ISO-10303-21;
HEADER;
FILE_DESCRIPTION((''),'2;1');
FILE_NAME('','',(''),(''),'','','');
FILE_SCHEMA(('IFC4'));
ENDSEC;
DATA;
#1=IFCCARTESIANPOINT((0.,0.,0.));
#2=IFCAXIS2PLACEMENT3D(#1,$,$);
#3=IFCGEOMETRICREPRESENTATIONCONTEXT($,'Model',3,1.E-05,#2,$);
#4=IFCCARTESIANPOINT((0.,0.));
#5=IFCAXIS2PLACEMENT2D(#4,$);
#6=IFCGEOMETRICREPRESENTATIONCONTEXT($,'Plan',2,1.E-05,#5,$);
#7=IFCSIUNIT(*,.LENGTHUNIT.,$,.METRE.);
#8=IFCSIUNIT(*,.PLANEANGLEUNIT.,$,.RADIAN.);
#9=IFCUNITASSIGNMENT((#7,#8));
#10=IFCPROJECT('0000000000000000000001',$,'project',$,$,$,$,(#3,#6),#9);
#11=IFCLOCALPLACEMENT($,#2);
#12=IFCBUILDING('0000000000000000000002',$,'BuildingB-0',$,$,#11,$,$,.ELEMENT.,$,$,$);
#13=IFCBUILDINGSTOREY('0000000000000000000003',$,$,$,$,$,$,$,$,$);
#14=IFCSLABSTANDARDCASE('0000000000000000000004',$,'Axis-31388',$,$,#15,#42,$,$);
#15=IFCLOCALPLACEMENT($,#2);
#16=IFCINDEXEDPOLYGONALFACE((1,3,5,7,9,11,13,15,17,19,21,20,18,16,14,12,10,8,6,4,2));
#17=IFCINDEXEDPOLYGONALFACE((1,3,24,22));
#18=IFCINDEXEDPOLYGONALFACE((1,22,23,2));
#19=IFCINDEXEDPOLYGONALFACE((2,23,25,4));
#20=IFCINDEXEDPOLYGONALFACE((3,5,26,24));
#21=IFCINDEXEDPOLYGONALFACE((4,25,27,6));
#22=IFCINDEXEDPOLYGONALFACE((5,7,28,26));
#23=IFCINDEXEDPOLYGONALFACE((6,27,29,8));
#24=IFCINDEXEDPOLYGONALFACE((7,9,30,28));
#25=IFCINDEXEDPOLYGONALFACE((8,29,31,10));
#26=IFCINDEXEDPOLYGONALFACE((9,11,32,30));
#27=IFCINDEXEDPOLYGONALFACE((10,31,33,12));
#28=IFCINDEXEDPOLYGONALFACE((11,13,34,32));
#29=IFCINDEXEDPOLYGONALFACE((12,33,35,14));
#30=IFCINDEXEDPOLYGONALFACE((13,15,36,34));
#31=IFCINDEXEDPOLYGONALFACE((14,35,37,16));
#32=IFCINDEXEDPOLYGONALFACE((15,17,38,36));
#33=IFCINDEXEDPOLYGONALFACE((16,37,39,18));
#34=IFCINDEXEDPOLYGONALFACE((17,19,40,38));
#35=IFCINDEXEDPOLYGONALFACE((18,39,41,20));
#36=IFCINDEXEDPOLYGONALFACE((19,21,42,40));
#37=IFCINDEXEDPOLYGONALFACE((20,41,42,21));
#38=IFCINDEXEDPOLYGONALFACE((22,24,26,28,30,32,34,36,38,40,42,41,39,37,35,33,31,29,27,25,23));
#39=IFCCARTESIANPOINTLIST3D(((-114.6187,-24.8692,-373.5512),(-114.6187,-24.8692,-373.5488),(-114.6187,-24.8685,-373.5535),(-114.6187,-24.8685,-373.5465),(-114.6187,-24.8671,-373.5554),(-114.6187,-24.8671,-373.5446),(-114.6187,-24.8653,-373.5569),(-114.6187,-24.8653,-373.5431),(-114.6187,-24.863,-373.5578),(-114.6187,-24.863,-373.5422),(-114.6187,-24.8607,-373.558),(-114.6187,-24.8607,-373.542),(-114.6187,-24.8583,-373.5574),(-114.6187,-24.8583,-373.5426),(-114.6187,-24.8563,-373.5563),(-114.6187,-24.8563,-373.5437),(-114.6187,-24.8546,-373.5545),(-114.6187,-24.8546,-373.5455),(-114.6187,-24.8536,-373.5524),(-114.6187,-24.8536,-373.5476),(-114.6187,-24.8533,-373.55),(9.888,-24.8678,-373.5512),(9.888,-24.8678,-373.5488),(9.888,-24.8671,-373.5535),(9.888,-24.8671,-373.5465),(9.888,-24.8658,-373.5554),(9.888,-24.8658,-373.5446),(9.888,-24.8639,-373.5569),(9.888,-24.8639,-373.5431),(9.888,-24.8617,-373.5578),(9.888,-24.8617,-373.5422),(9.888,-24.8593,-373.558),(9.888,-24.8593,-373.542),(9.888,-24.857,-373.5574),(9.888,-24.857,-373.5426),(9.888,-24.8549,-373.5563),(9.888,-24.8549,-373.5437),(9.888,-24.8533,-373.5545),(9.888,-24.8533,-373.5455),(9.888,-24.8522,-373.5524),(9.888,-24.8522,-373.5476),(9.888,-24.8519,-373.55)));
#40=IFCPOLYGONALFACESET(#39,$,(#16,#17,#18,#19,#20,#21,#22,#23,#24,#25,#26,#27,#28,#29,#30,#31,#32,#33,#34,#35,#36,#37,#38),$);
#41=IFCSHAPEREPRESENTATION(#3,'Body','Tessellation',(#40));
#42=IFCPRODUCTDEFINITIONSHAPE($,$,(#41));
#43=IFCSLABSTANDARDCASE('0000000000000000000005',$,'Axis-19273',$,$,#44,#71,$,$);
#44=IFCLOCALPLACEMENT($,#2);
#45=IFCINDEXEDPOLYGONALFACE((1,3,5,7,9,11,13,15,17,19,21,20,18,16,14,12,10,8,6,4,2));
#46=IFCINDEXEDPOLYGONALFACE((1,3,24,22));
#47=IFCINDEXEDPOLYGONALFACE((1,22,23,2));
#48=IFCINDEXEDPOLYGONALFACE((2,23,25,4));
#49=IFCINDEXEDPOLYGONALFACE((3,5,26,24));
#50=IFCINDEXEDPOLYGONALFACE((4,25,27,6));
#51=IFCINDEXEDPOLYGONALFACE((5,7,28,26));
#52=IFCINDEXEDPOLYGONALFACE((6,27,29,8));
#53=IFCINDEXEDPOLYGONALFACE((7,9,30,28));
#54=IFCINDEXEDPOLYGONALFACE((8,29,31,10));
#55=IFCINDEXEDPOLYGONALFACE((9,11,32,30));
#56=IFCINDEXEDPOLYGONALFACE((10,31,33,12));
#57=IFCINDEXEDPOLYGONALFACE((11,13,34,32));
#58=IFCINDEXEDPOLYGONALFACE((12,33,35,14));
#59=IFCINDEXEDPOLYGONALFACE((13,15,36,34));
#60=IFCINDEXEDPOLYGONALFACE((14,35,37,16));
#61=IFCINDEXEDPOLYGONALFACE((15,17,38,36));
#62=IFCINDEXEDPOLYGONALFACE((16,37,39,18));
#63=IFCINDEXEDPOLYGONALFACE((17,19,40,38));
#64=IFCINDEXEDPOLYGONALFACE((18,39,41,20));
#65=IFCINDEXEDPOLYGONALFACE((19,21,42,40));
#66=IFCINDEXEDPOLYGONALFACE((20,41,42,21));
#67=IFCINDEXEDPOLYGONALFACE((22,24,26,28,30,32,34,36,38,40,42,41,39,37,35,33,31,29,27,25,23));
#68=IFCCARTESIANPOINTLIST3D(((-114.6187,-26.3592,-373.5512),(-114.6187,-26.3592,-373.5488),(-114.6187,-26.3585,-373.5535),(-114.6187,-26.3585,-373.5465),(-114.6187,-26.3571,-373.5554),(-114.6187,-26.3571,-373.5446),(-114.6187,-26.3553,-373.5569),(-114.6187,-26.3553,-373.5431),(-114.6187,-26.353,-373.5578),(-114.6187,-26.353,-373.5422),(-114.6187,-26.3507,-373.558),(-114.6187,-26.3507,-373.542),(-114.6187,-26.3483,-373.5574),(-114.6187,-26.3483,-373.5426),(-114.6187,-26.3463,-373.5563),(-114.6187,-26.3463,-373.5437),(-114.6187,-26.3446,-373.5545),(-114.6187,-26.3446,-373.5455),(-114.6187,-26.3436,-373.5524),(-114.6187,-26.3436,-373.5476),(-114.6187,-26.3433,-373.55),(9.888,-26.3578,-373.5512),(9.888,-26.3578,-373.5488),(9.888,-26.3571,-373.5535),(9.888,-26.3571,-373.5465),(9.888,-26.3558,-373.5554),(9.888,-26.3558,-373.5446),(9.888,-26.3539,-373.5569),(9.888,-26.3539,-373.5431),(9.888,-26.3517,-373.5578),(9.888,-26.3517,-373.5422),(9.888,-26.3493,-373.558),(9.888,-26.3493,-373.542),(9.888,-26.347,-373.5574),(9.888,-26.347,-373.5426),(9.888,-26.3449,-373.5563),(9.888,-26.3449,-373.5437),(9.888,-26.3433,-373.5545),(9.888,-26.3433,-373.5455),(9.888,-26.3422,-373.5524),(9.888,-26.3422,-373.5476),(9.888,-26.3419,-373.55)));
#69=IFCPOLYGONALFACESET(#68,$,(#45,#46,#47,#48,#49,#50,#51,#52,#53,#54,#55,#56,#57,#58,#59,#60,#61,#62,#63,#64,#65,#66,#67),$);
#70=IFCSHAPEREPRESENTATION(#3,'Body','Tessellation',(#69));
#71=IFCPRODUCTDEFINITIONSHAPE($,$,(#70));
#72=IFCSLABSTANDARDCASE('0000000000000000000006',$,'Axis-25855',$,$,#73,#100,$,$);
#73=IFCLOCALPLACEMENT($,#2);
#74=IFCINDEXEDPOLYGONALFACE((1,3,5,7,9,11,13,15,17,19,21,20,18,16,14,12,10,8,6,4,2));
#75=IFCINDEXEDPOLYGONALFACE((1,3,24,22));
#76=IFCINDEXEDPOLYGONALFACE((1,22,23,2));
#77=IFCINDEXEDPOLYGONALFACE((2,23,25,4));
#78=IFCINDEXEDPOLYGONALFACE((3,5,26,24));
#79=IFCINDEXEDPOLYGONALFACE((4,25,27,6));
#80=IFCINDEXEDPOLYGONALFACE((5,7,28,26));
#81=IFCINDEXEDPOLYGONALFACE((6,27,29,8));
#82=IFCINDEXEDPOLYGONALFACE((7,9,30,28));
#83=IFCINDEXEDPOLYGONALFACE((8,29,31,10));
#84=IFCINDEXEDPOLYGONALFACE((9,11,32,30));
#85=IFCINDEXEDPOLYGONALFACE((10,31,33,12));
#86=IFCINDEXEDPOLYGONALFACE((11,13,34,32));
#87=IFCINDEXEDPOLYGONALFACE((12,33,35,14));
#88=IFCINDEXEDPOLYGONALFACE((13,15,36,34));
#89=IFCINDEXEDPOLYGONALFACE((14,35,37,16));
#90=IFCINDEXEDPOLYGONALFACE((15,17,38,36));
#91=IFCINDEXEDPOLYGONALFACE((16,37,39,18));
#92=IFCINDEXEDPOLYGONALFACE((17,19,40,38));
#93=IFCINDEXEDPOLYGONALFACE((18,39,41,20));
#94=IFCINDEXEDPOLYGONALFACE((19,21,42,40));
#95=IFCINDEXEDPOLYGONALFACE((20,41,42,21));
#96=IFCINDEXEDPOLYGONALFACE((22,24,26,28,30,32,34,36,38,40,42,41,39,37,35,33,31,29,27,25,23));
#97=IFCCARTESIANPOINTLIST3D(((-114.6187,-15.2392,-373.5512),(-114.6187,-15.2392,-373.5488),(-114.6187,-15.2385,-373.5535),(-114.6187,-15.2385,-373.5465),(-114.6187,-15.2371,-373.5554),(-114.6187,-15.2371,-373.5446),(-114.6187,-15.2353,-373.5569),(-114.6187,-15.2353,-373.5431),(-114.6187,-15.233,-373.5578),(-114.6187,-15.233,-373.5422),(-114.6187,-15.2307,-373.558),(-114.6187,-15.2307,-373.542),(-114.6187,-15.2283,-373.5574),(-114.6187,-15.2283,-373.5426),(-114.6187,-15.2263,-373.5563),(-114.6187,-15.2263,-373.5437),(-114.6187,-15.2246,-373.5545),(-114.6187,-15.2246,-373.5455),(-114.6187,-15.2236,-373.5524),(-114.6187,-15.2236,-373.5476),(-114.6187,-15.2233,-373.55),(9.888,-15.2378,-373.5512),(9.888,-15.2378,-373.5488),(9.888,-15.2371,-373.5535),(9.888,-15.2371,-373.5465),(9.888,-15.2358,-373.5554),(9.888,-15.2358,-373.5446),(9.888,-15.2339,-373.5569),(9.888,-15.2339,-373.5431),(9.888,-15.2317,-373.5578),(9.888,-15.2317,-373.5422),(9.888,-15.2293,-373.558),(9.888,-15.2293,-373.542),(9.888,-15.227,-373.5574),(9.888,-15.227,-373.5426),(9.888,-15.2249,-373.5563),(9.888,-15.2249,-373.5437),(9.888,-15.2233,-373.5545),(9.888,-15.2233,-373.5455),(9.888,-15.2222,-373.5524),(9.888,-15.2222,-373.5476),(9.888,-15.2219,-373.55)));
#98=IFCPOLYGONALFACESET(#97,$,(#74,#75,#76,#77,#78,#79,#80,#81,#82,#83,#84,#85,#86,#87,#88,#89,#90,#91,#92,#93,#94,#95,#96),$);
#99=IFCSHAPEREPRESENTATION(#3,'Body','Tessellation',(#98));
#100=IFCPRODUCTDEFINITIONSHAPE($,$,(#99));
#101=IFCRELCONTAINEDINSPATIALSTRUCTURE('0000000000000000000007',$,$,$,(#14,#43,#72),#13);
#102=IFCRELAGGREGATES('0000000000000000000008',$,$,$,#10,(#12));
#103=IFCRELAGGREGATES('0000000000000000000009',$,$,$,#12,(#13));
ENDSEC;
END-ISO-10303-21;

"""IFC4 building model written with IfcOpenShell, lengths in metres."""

from ifc_helpers import new_model, entity, si_unit, origin, origin_2d, place, context, project, spatial, element, save


model = new_model("IFC4")

# Units and contexts
model_context = context("Model", 3, precision=1e-05, world=origin())
plan_context = context("Plan", 2, precision=1e-05, world=origin_2d())
ifc_project = project(units=[si_unit("LENGTHUNIT", "METRE"), si_unit("PLANEANGLEUNIT", "RADIAN")], contexts=[model_context, plan_context])

# Building, storey
building_placement = place(None, origin())
building = spatial("IfcBuilding", under=ifc_project, at=building_placement, Name="BuildingB-0", CompositionType="ELEMENT")
storey = spatial("IfcBuildingStorey", under=building)

# Slabs
element("IfcSlabStandardCase", 1, inside=storey, Name="Axis-31388", context=model_context, shape_type="AdvancedSweptSolid", body=[
    entity("IfcSurfaceCurveSweptAreaSolid", entity("IfcCircleProfileDef", "AREA", None, None, 0.008), None, entity("IfcPolyline", [entity("IfcCartesianPoint", [-9.888, 24.8599, 373.55]), entity("IfcCartesianPoint", [114.6187, 24.8613, 373.55])]), None, None, entity("IfcPlane", entity("IfcAxis2Placement3D", entity("IfcCartesianPoint", [-9.888, 24.8599, 373.55]), entity("IfcDirection", [0.0, 0.0, 1.0]), entity("IfcDirection", [1.0, 0.0, 0.0])))),
    entity("IfcSurfaceCurveSweptAreaSolid", entity("IfcCircleProfileDef", "AREA", None, None, 0.008), None, entity("IfcCircle", entity("IfcAxis2Placement2D", entity("IfcCartesianPoint", [-10.1215, 24.8599, 373.55])), 0.35), None, None, entity("IfcPlane", entity("IfcAxis2Placement3D", entity("IfcCartesianPoint", [-10.1215, 24.8599, 373.55]), entity("IfcDirection", [0.0, 0.0, 1.0]), entity("IfcDirection", [1.0, 0.0, 0.0])))),
    entity("IfcSurfaceCurveSweptAreaSolid", entity("IfcCircleProfileDef", "AREA", None, None, 0.008), None, entity("IfcCircle", entity("IfcAxis2Placement2D", entity("IfcCartesianPoint", [114.8522, 24.8613, 373.55])), 0.35), None, None, entity("IfcPlane", entity("IfcAxis2Placement3D", entity("IfcCartesianPoint", [114.8522, 24.8613, 373.55]), entity("IfcDirection", [0.0, 0.0, 1.0]), entity("IfcDirection", [1.0, 0.0, 0.0])))),
])
element("IfcSlabStandardCase", 2, inside=storey, Name="Axis-19273", context=model_context, shape_type="AdvancedSweptSolid", body=[
    entity("IfcSurfaceCurveSweptAreaSolid", entity("IfcCircleProfileDef", "AREA", None, None, 0.008), None, entity("IfcPolyline", [entity("IfcCartesianPoint", [-9.888, 26.3499, 373.55]), entity("IfcCartesianPoint", [114.6187, 26.3513, 373.55])]), None, None, entity("IfcPlane", entity("IfcAxis2Placement3D", entity("IfcCartesianPoint", [-9.888, 26.3499, 373.55]), entity("IfcDirection", [0.0, 0.0, 1.0]), entity("IfcDirection", [1.0, 0.0, 0.0])))),
    entity("IfcSurfaceCurveSweptAreaSolid", entity("IfcCircleProfileDef", "AREA", None, None, 0.008), None, entity("IfcCircle", entity("IfcAxis2Placement2D", entity("IfcCartesianPoint", [-10.0987, 26.3513, 373.55])), 0.35), None, None, entity("IfcPlane", entity("IfcAxis2Placement3D", entity("IfcCartesianPoint", [-10.0987, 26.3513, 373.55]), entity("IfcDirection", [0.0, 0.0, 1.0]), entity("IfcDirection", [1.0, 0.0, 0.0])))),
    entity("IfcSurfaceCurveSweptAreaSolid", entity("IfcCircleProfileDef", "AREA", None, None, 0.008), None, entity("IfcCircle", entity("IfcAxis2Placement2D", entity("IfcCartesianPoint", [114.8522, 26.3513, 373.55])), 0.35), None, None, entity("IfcPlane", entity("IfcAxis2Placement3D", entity("IfcCartesianPoint", [114.8522, 26.3513, 373.55]), entity("IfcDirection", [0.0, 0.0, 1.0]), entity("IfcDirection", [1.0, 0.0, 0.0])))),
])
element("IfcSlabStandardCase", 3, inside=storey, Name="Axis-25855", context=model_context, shape_type="AdvancedSweptSolid", body=[
    entity("IfcSurfaceCurveSweptAreaSolid", entity("IfcCircleProfileDef", "AREA", None, None, 0.008), None, entity("IfcPolyline", [entity("IfcCartesianPoint", [-9.888, 15.2299, 373.55]), entity("IfcCartesianPoint", [114.6187, 15.2313, 373.55])]), None, None, entity("IfcPlane", entity("IfcAxis2Placement3D", entity("IfcCartesianPoint", [-9.888, 15.2299, 373.55]), entity("IfcDirection", [0.0, 0.0, 1.0]), entity("IfcDirection", [1.0, 0.0, 0.0])))),
    entity("IfcSurfaceCurveSweptAreaSolid", entity("IfcCircleProfileDef", "AREA", None, None, 0.008), None, entity("IfcCircle", entity("IfcAxis2Placement2D", entity("IfcCartesianPoint", [-10.1217, 15.2299, 373.55])), 0.35), None, None, entity("IfcPlane", entity("IfcAxis2Placement3D", entity("IfcCartesianPoint", [-10.1217, 15.2299, 373.55]), entity("IfcDirection", [0.0, 0.0, 1.0]), entity("IfcDirection", [1.0, 0.0, 0.0])))),
    entity("IfcSurfaceCurveSweptAreaSolid", entity("IfcCircleProfileDef", "AREA", None, None, 0.008), None, entity("IfcCircle", entity("IfcAxis2Placement2D", entity("IfcCartesianPoint", [114.8519, 15.2313, 373.55])), 0.35), None, None, entity("IfcPlane", entity("IfcAxis2Placement3D", entity("IfcCartesianPoint", [114.8519, 15.2313, 373.55]), entity("IfcDirection", [0.0, 0.0, 1.0]), entity("IfcDirection", [1.0, 0.0, 0.0])))),
])

save(model, "model.ifc")
